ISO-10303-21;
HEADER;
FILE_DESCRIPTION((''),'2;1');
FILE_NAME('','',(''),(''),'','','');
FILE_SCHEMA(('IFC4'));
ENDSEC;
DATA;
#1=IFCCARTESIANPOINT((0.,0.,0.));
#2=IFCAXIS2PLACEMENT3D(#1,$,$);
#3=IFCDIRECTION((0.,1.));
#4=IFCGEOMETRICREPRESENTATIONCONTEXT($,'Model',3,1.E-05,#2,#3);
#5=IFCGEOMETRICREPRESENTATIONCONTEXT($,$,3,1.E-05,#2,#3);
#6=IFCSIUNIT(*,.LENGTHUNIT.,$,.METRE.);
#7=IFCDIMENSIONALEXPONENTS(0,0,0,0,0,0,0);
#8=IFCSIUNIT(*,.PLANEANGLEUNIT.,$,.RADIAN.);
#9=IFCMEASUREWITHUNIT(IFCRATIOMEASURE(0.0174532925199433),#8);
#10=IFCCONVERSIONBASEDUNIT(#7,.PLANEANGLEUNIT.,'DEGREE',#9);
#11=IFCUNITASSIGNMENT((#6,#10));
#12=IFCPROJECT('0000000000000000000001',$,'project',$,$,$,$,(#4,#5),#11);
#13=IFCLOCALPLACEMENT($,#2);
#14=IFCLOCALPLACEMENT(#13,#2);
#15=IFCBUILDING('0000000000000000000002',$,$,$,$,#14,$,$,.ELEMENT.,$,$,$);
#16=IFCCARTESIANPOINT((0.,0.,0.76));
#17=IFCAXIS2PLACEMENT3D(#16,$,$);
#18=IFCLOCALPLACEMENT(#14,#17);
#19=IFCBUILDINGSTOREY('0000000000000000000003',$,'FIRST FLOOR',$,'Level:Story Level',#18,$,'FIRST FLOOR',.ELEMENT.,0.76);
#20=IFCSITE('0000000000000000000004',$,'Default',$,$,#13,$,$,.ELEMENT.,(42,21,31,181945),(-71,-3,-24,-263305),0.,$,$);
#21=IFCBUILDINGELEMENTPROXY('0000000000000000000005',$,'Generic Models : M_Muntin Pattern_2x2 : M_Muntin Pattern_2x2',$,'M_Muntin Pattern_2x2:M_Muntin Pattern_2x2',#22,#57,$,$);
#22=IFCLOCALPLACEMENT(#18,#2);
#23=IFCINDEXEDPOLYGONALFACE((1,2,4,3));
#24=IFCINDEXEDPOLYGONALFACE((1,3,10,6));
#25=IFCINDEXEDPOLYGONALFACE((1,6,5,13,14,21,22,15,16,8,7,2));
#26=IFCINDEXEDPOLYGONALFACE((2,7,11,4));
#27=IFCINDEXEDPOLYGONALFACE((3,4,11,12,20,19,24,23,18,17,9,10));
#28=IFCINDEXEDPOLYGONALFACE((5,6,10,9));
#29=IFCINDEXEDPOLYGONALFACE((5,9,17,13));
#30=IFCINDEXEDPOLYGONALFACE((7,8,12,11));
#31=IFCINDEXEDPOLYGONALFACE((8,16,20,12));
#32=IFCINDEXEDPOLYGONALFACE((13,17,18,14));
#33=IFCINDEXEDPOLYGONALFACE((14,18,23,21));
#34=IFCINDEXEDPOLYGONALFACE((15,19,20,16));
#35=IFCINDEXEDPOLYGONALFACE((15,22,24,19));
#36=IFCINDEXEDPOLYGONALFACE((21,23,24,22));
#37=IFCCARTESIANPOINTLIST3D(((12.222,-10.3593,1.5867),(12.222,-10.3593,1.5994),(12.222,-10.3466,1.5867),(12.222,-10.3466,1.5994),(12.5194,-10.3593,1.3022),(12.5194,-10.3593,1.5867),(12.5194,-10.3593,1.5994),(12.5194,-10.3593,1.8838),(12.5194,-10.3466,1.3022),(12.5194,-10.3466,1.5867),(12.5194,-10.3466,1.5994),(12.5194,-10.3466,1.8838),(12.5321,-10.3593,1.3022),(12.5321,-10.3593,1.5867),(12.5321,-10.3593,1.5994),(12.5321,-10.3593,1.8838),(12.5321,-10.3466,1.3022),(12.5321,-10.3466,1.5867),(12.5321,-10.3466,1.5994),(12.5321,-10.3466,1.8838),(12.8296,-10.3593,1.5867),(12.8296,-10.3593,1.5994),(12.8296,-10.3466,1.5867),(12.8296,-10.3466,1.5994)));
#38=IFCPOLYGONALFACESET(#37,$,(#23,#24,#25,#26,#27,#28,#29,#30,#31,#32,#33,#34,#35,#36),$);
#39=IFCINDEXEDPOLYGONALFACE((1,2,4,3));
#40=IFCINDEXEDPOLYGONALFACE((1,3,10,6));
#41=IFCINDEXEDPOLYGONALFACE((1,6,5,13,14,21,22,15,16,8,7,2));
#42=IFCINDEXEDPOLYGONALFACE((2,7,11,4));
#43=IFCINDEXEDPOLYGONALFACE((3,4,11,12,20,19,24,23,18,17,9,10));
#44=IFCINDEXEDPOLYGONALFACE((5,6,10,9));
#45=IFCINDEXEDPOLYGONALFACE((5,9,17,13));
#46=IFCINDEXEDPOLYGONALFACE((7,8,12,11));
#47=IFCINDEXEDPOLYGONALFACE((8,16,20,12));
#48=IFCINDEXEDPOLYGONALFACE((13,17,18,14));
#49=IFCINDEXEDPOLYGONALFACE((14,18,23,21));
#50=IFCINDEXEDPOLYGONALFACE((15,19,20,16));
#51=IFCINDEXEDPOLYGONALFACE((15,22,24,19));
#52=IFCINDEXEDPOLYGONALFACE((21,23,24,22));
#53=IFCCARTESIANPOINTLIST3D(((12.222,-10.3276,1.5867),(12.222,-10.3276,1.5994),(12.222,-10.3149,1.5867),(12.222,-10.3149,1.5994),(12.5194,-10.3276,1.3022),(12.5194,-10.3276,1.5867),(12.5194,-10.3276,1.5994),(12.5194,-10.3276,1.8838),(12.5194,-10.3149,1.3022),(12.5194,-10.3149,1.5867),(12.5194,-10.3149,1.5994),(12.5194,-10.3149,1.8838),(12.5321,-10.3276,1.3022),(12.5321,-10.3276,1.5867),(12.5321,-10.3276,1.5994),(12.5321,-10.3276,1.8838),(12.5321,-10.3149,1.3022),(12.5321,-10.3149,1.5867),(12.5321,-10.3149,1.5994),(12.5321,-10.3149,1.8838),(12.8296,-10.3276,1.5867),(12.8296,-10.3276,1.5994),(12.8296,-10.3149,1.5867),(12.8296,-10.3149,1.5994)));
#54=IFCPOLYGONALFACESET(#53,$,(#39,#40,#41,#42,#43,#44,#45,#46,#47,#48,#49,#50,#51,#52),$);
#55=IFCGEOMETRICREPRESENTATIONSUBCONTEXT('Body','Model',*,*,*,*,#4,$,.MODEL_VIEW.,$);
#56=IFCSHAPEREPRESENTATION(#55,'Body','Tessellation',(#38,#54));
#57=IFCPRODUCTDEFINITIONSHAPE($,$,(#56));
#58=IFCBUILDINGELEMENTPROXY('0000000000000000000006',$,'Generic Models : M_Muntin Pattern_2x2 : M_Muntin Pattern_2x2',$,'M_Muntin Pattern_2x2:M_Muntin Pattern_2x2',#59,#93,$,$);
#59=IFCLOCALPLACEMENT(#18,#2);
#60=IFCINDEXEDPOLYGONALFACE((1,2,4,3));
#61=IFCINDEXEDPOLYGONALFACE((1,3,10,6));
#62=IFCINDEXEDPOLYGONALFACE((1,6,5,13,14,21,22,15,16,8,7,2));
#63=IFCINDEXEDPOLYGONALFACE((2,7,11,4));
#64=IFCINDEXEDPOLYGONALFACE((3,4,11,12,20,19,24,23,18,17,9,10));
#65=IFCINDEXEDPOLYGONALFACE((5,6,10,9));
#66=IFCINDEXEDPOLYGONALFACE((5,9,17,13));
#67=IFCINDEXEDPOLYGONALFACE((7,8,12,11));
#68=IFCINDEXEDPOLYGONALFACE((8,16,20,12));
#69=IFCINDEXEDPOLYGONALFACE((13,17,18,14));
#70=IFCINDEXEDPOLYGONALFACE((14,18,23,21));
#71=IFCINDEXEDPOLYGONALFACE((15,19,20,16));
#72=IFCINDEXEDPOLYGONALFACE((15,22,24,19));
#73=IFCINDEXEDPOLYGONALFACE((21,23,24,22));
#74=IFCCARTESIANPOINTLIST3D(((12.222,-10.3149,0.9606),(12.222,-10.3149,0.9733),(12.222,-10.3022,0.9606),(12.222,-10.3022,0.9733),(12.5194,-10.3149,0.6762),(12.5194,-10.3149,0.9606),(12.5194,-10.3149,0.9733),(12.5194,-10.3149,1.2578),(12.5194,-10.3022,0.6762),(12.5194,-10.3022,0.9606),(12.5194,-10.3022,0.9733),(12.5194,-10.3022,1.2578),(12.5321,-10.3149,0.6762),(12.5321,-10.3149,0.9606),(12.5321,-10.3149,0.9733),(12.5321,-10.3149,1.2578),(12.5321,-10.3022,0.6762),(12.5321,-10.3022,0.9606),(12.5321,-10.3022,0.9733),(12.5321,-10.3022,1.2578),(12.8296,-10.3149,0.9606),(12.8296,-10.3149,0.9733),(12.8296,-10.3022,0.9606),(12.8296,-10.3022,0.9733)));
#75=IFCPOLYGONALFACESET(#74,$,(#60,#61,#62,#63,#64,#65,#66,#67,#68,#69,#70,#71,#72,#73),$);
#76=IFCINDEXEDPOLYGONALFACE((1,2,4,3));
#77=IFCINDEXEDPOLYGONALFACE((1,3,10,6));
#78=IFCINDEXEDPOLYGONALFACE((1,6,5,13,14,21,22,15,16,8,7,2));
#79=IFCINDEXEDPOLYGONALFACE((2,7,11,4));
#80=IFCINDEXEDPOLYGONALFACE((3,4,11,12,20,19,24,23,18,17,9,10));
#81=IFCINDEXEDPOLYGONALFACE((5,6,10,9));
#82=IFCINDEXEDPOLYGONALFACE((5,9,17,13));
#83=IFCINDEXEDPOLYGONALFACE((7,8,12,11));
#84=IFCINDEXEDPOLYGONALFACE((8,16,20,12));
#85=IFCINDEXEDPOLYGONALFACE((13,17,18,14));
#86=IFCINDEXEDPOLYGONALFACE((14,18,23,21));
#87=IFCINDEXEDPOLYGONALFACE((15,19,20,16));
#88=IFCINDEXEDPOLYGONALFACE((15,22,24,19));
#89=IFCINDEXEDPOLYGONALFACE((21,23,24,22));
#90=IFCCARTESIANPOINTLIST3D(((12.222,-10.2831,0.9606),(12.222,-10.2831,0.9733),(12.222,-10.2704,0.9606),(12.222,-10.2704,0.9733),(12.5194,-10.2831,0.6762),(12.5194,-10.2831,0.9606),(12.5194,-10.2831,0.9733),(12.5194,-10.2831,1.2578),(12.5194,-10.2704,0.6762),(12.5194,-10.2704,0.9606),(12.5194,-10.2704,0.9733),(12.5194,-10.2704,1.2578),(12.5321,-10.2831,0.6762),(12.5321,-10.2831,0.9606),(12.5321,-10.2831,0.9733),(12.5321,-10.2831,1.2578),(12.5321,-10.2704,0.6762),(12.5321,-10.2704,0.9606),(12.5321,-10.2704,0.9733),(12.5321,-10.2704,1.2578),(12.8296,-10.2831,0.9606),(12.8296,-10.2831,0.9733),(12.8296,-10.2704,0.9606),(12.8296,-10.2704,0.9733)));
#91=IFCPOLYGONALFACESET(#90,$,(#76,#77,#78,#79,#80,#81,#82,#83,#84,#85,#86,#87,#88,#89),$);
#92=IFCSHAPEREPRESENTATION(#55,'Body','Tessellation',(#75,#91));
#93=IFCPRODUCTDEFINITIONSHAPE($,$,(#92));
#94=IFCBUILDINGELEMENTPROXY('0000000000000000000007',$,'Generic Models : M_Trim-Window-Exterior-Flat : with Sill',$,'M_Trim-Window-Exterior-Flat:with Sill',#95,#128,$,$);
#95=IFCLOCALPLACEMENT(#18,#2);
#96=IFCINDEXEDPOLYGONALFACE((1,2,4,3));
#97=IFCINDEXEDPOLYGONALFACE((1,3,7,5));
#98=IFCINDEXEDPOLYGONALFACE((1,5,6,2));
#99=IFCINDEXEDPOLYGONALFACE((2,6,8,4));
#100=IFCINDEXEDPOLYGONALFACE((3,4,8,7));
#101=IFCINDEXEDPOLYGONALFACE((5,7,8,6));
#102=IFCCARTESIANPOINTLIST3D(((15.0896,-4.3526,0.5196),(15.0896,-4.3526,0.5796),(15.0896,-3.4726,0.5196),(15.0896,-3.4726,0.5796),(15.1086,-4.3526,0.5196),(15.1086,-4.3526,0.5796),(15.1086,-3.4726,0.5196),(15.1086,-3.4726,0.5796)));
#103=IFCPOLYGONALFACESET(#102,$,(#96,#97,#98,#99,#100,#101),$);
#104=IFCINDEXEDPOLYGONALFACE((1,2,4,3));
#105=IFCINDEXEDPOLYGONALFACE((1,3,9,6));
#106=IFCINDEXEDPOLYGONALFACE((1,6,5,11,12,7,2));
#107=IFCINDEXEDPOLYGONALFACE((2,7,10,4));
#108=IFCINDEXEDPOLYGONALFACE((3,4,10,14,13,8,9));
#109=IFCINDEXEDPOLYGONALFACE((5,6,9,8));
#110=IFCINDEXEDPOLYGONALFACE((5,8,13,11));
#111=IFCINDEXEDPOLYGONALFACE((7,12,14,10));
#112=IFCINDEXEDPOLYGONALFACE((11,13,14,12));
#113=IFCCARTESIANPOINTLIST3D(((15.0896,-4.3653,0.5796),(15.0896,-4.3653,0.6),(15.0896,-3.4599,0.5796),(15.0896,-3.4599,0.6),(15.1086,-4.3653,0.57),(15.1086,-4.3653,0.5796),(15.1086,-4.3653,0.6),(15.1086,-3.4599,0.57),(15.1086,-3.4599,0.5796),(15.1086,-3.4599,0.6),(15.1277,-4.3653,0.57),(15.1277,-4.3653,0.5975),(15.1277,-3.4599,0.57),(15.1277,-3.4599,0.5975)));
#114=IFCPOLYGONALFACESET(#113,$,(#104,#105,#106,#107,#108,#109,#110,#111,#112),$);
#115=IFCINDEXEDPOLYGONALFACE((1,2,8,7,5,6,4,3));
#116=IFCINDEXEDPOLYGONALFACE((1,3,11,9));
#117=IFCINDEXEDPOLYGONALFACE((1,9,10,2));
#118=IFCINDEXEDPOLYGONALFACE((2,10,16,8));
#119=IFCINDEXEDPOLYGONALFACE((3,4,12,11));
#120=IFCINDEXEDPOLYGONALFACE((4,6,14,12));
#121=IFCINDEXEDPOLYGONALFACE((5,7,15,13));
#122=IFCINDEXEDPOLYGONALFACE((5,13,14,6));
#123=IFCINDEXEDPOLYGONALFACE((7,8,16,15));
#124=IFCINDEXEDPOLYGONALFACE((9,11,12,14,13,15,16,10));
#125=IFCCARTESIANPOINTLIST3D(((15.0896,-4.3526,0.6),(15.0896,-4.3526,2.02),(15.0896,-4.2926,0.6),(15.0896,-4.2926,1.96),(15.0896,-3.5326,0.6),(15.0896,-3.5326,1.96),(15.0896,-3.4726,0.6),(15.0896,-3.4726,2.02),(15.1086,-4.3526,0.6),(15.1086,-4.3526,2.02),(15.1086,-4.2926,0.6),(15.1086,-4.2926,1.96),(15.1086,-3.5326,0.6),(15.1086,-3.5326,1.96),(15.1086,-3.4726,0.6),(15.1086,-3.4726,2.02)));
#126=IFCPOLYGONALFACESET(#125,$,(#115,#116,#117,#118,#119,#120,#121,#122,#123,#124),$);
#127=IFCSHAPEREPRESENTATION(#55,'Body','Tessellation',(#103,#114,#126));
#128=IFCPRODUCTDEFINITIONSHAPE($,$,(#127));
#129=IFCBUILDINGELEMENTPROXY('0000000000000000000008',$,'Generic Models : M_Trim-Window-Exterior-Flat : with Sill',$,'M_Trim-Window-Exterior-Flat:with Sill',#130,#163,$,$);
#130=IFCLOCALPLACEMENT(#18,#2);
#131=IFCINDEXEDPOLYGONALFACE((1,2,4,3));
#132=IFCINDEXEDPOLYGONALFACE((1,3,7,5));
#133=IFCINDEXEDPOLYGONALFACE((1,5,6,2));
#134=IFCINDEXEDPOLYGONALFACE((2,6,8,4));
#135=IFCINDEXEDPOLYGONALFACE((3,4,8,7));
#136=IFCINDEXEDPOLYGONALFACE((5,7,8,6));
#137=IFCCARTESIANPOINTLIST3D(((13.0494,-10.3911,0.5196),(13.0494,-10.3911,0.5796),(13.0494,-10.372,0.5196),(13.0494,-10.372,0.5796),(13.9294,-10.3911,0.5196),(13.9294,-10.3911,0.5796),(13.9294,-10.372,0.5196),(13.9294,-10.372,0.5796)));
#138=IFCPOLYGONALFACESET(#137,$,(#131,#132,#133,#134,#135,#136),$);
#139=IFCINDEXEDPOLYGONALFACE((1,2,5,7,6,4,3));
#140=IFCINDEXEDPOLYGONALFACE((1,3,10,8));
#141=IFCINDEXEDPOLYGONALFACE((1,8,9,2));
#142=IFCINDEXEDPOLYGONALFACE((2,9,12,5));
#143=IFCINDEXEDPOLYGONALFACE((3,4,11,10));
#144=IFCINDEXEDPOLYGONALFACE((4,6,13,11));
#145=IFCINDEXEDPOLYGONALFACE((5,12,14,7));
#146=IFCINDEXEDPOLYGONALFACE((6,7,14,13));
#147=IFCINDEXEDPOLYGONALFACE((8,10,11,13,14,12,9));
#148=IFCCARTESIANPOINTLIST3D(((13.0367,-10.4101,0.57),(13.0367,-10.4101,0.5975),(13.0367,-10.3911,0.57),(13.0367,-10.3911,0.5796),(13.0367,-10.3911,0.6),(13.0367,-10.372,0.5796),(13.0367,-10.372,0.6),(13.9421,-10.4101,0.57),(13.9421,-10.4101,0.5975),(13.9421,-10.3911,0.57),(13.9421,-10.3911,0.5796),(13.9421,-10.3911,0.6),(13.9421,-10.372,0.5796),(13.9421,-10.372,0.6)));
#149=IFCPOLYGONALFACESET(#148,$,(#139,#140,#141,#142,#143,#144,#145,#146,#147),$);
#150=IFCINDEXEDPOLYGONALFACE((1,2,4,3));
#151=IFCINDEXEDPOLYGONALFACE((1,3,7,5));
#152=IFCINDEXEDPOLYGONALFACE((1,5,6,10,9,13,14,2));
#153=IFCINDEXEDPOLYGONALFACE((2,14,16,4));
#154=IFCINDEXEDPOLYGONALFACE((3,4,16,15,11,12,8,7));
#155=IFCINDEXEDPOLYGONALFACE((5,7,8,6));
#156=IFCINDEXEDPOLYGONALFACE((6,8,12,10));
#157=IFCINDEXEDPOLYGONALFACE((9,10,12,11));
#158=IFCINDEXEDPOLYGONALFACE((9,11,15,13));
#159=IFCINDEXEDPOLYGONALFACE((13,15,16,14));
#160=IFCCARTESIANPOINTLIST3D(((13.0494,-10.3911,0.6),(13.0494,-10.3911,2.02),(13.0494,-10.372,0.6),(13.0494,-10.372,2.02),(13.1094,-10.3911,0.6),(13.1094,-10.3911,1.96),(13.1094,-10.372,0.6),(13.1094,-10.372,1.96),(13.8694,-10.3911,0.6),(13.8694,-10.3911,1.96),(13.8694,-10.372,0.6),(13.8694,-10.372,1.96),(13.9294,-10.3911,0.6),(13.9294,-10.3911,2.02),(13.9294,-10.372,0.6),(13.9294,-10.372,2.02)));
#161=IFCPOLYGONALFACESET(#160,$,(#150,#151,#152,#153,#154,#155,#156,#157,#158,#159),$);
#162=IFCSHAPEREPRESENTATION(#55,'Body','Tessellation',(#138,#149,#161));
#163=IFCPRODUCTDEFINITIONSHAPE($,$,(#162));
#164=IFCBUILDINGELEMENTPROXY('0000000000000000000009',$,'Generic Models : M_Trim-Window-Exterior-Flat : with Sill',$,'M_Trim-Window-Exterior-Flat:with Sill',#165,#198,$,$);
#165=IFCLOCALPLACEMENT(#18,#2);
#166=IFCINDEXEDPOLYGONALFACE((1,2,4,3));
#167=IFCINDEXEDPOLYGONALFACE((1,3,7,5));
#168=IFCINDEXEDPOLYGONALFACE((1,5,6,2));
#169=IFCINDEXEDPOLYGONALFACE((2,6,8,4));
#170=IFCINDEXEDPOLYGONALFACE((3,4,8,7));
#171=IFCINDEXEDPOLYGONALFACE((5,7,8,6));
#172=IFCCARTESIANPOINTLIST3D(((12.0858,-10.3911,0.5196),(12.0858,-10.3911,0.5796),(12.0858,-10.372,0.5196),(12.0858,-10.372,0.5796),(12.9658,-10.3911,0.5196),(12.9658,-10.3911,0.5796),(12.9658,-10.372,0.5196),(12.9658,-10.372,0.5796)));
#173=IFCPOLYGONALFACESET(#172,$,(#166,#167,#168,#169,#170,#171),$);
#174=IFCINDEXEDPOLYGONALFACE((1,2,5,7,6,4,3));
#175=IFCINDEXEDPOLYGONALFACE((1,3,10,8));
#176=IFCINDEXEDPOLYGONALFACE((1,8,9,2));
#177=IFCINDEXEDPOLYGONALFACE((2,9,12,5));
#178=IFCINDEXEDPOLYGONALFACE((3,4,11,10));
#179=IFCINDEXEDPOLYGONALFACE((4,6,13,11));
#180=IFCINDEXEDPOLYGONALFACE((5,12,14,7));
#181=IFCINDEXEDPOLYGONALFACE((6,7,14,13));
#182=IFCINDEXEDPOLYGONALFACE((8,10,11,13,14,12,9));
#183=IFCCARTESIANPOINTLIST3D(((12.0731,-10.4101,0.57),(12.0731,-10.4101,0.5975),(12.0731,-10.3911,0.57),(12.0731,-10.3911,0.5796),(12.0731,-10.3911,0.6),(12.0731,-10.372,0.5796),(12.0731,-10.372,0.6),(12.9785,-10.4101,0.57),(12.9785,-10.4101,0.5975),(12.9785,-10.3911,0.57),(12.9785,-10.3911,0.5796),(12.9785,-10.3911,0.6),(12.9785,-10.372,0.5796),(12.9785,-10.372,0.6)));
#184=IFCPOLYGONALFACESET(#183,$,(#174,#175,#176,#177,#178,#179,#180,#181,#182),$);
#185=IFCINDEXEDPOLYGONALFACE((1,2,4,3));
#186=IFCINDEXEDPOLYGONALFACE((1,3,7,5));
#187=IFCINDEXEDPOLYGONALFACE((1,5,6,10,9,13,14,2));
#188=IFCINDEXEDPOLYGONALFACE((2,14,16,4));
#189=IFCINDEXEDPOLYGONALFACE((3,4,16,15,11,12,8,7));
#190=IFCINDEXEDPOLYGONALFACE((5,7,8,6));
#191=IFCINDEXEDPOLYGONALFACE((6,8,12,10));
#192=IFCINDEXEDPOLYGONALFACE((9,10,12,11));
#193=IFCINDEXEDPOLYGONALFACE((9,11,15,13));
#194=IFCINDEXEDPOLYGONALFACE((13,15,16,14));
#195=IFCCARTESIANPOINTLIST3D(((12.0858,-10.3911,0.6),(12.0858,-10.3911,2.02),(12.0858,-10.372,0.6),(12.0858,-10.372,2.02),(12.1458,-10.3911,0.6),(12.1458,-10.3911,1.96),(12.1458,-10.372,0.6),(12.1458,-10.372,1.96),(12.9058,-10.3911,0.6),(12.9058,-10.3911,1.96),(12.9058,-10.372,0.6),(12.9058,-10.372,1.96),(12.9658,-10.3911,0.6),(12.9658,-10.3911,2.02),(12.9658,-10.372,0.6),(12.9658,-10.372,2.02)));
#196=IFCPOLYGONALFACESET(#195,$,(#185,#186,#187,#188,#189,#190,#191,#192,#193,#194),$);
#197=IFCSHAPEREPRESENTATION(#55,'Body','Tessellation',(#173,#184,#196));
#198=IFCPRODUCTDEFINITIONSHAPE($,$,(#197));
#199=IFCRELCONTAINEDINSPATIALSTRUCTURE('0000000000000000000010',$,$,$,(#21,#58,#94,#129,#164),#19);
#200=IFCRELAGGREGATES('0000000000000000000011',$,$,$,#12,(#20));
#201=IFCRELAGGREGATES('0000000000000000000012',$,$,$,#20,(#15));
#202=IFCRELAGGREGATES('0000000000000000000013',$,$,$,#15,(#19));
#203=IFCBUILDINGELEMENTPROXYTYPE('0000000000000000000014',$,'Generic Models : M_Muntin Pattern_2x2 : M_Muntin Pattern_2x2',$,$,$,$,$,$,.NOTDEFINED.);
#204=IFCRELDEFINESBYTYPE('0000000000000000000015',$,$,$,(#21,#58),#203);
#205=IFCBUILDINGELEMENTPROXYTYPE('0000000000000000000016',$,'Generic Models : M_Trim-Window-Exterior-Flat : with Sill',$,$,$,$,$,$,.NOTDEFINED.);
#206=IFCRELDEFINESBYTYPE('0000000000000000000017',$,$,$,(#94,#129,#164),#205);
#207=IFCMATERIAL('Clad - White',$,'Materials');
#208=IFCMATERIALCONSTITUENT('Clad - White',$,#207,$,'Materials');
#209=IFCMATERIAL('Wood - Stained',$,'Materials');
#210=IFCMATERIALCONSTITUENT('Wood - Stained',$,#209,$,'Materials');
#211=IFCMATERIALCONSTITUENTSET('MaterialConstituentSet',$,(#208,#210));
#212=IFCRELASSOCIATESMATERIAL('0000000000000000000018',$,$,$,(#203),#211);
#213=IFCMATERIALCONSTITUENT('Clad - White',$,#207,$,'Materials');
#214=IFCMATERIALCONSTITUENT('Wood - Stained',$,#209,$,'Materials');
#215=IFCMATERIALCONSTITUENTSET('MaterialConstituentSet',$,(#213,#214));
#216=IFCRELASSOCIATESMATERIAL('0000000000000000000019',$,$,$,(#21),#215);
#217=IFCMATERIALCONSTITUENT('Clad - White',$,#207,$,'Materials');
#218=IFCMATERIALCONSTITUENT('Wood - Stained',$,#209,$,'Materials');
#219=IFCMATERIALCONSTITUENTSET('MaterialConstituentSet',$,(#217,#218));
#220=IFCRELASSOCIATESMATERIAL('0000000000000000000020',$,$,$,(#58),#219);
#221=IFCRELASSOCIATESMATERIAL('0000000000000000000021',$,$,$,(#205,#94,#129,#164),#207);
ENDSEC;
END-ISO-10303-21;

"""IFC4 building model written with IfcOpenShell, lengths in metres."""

from ifc_helpers import new_model, entity, si_unit, converted_unit, direction, frame, frame_2d, origin, place, context, subcontext, project, spatial, polyline, rectangle, outline, extrude, source, transform, mapped, material, constituent, constituent_set, type_object, type_shapes, element, save


model = new_model("IFC4")

# Units and contexts
model_context = context("Model", 3, precision=1e-05, world=origin(), true_north=direction((0.0, 1.0)))
context_of_model = context(None, 3, precision=1e-05, world=origin(), true_north=direction((0.0, 1.0)))
body_context = subcontext(model_context, "Body", "Model", "MODEL_VIEW")
ifc_project = project(units=[si_unit("LENGTHUNIT", "METRE"), converted_unit("PLANEANGLEUNIT", "DEGREE", entity("IfcRatioMeasure", 0.0174532925199433), si_unit("PLANEANGLEUNIT", "RADIAN"), dimensions=[0, 0, 0, 0, 0, 0, 0])], contexts=[model_context, context_of_model])

# Site, building, storey
site_placement = place(None, origin())
site = spatial("IfcSite", under=ifc_project, at=site_placement, Name="Default", CompositionType="ELEMENT", RefLatitude=(42, 21, 31, 181945), RefLongitude=(-71, -3, -24, -263305), RefElevation=0.0)
building_placement = place(site_placement, origin())
building = spatial("IfcBuilding", under=site, at=building_placement, CompositionType="ELEMENT")
storey_placement = place(building_placement, frame((0.0, 0.0, 0.76)))
storey = spatial("IfcBuildingStorey", under=building, at=storey_placement, Name="FIRST FLOOR", ObjectType="Level:Story Level", LongName="FIRST FLOOR", CompositionType="ELEMENT", Elevation=0.76)

# Shared definitions
ifc_material_1 = material(Name="Wood - Stained", Category="Materials")

# Building element proxies
ifc_material_2 = material(Name="Clad - White", Category="Materials")
ifc_constituent_1 = constituent(ifc_material_2, Name="Clad - White", Category="Materials")
ifc_constituent_2 = constituent(ifc_material_1, Name="Wood - Stained", Category="Materials")
ifc_constituent_set_1 = constituent_set(constituents=[ifc_constituent_1, ifc_constituent_2], Name="MaterialConstituentSet")
building_element_proxy_type_1 = type_object("IfcBuildingElementProxyType", Name="Generic Models : M_Muntin Pattern_2x2 : M_Muntin Pattern_2x2", PredefinedType="NOTDEFINED", material=ifc_constituent_set_1)
shared_shape_1 = source(origin(), body_context, "Body", "SweptSolid", [
    extrude(outline(polyline([(0.0064, -0.0064), (0.2908, -0.0064), (0.2908, 0.0063), (0.0064, 0.0063), (0.0064, 0.3038), (-0.0063, 0.3038), (-0.0063, 0.0063), (-0.2908, 0.0063), (-0.2908, -0.0064), (-0.0063, -0.0064), (-0.0063, -0.3038), (0.0064, -0.3038), (0.0064, -0.0064)])), frame((0.0, 0.0095, 0.2908), z_axis=(0.0, 1.0, 0.0), x_axis=(0.0, 0.0, 1.0)), (0.0, 0.0, 1.0), 0.0127),
    extrude(outline(polyline([(0.0064, -0.0064), (0.2908, -0.0064), (0.2908, 0.0063), (0.0064, 0.0063), (0.0064, 0.3038), (-0.0063, 0.3038), (-0.0063, 0.0063), (-0.2908, 0.0063), (-0.2908, -0.0064), (-0.0063, -0.0064), (-0.0063, -0.3038), (0.0064, -0.3038), (0.0064, -0.0064)])), frame((0.0, -0.0222, 0.2908), z_axis=(0.0, 1.0, 0.0), x_axis=(0.0, 0.0, 1.0)), (0.0, 0.0, 1.0), 0.0127),
])
type_shapes(building_element_proxy_type_1, [shared_shape_1])
ifc_constituent_3 = constituent(ifc_material_2, Name="Clad - White", Category="Materials")
ifc_constituent_4 = constituent(ifc_material_1, Name="Wood - Stained", Category="Materials")
ifc_constituent_set_2 = constituent_set(constituents=[ifc_constituent_3, ifc_constituent_4], Name="MaterialConstituentSet")
proxy_1_placement = place(storey_placement, frame((12.5258, -10.3371, 1.3022), z_axis=(0.0, 0.0, 1.0), x_axis=(-1.0, 0.0, 0.0)))
element("IfcBuildingElementProxy", 1, at=proxy_1_placement, inside=storey, type_object=building_element_proxy_type_1, material=ifc_constituent_set_2, Name="Generic Models : M_Muntin Pattern_2x2 : M_Muntin Pattern_2x2", ObjectType="M_Muntin Pattern_2x2:M_Muntin Pattern_2x2", context=body_context, shape_type="MappedRepresentation", body=[
    mapped(shared_shape_1, transform((0.0, 0.0, 0.0), scale=1.0)),
])
ifc_constituent_5 = constituent(ifc_material_2, Name="Clad - White", Category="Materials")
ifc_constituent_6 = constituent(ifc_material_1, Name="Wood - Stained", Category="Materials")
ifc_constituent_set_3 = constituent_set(constituents=[ifc_constituent_5, ifc_constituent_6], Name="MaterialConstituentSet")
proxy_2_placement = place(storey_placement, frame((12.5258, -10.2926, 0.6762), z_axis=(0.0, 0.0, 1.0), x_axis=(-1.0, 0.0, 0.0)))
element("IfcBuildingElementProxy", 2, at=proxy_2_placement, inside=storey, type_object=building_element_proxy_type_1, material=ifc_constituent_set_3, Name="Generic Models : M_Muntin Pattern_2x2 : M_Muntin Pattern_2x2", ObjectType="M_Muntin Pattern_2x2:M_Muntin Pattern_2x2", context=body_context, shape_type="MappedRepresentation", body=[
    mapped(shared_shape_1, transform((0.0, 0.0, 0.0), scale=1.0)),
])
building_element_proxy_type_2 = type_object("IfcBuildingElementProxyType", Name="Generic Models : M_Trim-Window-Exterior-Flat : with Sill", PredefinedType="NOTDEFINED", material=ifc_material_2)
shared_shape_2 = source(origin(), body_context, "Body", "SweptSolid", [
    extrude(rectangle(XDim=0.88, YDim=0.06, at=frame_2d((0.0, 0.0), x_axis=(1.0, 0.0))), frame((0.0, -1.4104, 0.0), z_axis=(0.0, 0.0, 1.0), x_axis=(-1.0, 0.0, 0.0)), (0.0, 0.0, 1.0), 0.0191),
    extrude(outline(polyline([(-0.019, -0.0152), (0.0, -0.0152), (0.0, -0.0057), (0.019, -0.0057), (0.019, 0.0148), (0.0, 0.0148), (-0.019, 0.0123), (-0.019, -0.0152)])), frame((-0.4527, -1.3748, 0.019), z_axis=(1.0, 0.0, 0.0), x_axis=(0.0, 0.0, -1.0)), (0.0, 0.0, 1.0), 0.9054),
    extrude(outline(polyline([(-0.725, -0.44), (0.695, -0.44), (0.695, -0.38), (-0.665, -0.38), (-0.665, 0.38), (0.695, 0.38), (0.695, 0.44), (-0.725, 0.44), (-0.725, -0.44)])), frame((0.0, -0.665, 0.0), z_axis=(0.0, 0.0, 1.0), x_axis=(0.0, -1.0, 0.0)), (0.0, 0.0, 1.0), 0.0191),
])
type_shapes(building_element_proxy_type_2, [shared_shape_2])
for number, where, z_axis, x_axis, name in (
    (3, (15.0896, -3.9126, 1.96), (1.0, 0.0, 0.0), (0.0, 1.0, 0.0), "Generic Models : M_Trim-Window-Exterior-Flat : with Sill"),
    (4, (13.4894, -10.372, 1.96), (0.0, -1.0, 0.0), (1.0, 0.0, 0.0), "Generic Models : M_Trim-Window-Exterior-Flat : with Sill"),
    (5, (12.5258, -10.372, 1.96), (0.0, -1.0, 0.0), (1.0, 0.0, 0.0), "Generic Models : M_Trim-Window-Exterior-Flat : with Sill"),
):
    element("IfcBuildingElementProxy", number, at=place(storey_placement, frame(where, z_axis=z_axis, x_axis=x_axis)), inside=storey, type_object=building_element_proxy_type_2, material=ifc_material_2, Name=name, ObjectType="M_Trim-Window-Exterior-Flat:with Sill", context=body_context, shape_type="MappedRepresentation", body=[
        mapped(shared_shape_2, transform((0.0, 0.0, 0.0), scale=1.0)),
    ])

save(model, "model.ifc")
